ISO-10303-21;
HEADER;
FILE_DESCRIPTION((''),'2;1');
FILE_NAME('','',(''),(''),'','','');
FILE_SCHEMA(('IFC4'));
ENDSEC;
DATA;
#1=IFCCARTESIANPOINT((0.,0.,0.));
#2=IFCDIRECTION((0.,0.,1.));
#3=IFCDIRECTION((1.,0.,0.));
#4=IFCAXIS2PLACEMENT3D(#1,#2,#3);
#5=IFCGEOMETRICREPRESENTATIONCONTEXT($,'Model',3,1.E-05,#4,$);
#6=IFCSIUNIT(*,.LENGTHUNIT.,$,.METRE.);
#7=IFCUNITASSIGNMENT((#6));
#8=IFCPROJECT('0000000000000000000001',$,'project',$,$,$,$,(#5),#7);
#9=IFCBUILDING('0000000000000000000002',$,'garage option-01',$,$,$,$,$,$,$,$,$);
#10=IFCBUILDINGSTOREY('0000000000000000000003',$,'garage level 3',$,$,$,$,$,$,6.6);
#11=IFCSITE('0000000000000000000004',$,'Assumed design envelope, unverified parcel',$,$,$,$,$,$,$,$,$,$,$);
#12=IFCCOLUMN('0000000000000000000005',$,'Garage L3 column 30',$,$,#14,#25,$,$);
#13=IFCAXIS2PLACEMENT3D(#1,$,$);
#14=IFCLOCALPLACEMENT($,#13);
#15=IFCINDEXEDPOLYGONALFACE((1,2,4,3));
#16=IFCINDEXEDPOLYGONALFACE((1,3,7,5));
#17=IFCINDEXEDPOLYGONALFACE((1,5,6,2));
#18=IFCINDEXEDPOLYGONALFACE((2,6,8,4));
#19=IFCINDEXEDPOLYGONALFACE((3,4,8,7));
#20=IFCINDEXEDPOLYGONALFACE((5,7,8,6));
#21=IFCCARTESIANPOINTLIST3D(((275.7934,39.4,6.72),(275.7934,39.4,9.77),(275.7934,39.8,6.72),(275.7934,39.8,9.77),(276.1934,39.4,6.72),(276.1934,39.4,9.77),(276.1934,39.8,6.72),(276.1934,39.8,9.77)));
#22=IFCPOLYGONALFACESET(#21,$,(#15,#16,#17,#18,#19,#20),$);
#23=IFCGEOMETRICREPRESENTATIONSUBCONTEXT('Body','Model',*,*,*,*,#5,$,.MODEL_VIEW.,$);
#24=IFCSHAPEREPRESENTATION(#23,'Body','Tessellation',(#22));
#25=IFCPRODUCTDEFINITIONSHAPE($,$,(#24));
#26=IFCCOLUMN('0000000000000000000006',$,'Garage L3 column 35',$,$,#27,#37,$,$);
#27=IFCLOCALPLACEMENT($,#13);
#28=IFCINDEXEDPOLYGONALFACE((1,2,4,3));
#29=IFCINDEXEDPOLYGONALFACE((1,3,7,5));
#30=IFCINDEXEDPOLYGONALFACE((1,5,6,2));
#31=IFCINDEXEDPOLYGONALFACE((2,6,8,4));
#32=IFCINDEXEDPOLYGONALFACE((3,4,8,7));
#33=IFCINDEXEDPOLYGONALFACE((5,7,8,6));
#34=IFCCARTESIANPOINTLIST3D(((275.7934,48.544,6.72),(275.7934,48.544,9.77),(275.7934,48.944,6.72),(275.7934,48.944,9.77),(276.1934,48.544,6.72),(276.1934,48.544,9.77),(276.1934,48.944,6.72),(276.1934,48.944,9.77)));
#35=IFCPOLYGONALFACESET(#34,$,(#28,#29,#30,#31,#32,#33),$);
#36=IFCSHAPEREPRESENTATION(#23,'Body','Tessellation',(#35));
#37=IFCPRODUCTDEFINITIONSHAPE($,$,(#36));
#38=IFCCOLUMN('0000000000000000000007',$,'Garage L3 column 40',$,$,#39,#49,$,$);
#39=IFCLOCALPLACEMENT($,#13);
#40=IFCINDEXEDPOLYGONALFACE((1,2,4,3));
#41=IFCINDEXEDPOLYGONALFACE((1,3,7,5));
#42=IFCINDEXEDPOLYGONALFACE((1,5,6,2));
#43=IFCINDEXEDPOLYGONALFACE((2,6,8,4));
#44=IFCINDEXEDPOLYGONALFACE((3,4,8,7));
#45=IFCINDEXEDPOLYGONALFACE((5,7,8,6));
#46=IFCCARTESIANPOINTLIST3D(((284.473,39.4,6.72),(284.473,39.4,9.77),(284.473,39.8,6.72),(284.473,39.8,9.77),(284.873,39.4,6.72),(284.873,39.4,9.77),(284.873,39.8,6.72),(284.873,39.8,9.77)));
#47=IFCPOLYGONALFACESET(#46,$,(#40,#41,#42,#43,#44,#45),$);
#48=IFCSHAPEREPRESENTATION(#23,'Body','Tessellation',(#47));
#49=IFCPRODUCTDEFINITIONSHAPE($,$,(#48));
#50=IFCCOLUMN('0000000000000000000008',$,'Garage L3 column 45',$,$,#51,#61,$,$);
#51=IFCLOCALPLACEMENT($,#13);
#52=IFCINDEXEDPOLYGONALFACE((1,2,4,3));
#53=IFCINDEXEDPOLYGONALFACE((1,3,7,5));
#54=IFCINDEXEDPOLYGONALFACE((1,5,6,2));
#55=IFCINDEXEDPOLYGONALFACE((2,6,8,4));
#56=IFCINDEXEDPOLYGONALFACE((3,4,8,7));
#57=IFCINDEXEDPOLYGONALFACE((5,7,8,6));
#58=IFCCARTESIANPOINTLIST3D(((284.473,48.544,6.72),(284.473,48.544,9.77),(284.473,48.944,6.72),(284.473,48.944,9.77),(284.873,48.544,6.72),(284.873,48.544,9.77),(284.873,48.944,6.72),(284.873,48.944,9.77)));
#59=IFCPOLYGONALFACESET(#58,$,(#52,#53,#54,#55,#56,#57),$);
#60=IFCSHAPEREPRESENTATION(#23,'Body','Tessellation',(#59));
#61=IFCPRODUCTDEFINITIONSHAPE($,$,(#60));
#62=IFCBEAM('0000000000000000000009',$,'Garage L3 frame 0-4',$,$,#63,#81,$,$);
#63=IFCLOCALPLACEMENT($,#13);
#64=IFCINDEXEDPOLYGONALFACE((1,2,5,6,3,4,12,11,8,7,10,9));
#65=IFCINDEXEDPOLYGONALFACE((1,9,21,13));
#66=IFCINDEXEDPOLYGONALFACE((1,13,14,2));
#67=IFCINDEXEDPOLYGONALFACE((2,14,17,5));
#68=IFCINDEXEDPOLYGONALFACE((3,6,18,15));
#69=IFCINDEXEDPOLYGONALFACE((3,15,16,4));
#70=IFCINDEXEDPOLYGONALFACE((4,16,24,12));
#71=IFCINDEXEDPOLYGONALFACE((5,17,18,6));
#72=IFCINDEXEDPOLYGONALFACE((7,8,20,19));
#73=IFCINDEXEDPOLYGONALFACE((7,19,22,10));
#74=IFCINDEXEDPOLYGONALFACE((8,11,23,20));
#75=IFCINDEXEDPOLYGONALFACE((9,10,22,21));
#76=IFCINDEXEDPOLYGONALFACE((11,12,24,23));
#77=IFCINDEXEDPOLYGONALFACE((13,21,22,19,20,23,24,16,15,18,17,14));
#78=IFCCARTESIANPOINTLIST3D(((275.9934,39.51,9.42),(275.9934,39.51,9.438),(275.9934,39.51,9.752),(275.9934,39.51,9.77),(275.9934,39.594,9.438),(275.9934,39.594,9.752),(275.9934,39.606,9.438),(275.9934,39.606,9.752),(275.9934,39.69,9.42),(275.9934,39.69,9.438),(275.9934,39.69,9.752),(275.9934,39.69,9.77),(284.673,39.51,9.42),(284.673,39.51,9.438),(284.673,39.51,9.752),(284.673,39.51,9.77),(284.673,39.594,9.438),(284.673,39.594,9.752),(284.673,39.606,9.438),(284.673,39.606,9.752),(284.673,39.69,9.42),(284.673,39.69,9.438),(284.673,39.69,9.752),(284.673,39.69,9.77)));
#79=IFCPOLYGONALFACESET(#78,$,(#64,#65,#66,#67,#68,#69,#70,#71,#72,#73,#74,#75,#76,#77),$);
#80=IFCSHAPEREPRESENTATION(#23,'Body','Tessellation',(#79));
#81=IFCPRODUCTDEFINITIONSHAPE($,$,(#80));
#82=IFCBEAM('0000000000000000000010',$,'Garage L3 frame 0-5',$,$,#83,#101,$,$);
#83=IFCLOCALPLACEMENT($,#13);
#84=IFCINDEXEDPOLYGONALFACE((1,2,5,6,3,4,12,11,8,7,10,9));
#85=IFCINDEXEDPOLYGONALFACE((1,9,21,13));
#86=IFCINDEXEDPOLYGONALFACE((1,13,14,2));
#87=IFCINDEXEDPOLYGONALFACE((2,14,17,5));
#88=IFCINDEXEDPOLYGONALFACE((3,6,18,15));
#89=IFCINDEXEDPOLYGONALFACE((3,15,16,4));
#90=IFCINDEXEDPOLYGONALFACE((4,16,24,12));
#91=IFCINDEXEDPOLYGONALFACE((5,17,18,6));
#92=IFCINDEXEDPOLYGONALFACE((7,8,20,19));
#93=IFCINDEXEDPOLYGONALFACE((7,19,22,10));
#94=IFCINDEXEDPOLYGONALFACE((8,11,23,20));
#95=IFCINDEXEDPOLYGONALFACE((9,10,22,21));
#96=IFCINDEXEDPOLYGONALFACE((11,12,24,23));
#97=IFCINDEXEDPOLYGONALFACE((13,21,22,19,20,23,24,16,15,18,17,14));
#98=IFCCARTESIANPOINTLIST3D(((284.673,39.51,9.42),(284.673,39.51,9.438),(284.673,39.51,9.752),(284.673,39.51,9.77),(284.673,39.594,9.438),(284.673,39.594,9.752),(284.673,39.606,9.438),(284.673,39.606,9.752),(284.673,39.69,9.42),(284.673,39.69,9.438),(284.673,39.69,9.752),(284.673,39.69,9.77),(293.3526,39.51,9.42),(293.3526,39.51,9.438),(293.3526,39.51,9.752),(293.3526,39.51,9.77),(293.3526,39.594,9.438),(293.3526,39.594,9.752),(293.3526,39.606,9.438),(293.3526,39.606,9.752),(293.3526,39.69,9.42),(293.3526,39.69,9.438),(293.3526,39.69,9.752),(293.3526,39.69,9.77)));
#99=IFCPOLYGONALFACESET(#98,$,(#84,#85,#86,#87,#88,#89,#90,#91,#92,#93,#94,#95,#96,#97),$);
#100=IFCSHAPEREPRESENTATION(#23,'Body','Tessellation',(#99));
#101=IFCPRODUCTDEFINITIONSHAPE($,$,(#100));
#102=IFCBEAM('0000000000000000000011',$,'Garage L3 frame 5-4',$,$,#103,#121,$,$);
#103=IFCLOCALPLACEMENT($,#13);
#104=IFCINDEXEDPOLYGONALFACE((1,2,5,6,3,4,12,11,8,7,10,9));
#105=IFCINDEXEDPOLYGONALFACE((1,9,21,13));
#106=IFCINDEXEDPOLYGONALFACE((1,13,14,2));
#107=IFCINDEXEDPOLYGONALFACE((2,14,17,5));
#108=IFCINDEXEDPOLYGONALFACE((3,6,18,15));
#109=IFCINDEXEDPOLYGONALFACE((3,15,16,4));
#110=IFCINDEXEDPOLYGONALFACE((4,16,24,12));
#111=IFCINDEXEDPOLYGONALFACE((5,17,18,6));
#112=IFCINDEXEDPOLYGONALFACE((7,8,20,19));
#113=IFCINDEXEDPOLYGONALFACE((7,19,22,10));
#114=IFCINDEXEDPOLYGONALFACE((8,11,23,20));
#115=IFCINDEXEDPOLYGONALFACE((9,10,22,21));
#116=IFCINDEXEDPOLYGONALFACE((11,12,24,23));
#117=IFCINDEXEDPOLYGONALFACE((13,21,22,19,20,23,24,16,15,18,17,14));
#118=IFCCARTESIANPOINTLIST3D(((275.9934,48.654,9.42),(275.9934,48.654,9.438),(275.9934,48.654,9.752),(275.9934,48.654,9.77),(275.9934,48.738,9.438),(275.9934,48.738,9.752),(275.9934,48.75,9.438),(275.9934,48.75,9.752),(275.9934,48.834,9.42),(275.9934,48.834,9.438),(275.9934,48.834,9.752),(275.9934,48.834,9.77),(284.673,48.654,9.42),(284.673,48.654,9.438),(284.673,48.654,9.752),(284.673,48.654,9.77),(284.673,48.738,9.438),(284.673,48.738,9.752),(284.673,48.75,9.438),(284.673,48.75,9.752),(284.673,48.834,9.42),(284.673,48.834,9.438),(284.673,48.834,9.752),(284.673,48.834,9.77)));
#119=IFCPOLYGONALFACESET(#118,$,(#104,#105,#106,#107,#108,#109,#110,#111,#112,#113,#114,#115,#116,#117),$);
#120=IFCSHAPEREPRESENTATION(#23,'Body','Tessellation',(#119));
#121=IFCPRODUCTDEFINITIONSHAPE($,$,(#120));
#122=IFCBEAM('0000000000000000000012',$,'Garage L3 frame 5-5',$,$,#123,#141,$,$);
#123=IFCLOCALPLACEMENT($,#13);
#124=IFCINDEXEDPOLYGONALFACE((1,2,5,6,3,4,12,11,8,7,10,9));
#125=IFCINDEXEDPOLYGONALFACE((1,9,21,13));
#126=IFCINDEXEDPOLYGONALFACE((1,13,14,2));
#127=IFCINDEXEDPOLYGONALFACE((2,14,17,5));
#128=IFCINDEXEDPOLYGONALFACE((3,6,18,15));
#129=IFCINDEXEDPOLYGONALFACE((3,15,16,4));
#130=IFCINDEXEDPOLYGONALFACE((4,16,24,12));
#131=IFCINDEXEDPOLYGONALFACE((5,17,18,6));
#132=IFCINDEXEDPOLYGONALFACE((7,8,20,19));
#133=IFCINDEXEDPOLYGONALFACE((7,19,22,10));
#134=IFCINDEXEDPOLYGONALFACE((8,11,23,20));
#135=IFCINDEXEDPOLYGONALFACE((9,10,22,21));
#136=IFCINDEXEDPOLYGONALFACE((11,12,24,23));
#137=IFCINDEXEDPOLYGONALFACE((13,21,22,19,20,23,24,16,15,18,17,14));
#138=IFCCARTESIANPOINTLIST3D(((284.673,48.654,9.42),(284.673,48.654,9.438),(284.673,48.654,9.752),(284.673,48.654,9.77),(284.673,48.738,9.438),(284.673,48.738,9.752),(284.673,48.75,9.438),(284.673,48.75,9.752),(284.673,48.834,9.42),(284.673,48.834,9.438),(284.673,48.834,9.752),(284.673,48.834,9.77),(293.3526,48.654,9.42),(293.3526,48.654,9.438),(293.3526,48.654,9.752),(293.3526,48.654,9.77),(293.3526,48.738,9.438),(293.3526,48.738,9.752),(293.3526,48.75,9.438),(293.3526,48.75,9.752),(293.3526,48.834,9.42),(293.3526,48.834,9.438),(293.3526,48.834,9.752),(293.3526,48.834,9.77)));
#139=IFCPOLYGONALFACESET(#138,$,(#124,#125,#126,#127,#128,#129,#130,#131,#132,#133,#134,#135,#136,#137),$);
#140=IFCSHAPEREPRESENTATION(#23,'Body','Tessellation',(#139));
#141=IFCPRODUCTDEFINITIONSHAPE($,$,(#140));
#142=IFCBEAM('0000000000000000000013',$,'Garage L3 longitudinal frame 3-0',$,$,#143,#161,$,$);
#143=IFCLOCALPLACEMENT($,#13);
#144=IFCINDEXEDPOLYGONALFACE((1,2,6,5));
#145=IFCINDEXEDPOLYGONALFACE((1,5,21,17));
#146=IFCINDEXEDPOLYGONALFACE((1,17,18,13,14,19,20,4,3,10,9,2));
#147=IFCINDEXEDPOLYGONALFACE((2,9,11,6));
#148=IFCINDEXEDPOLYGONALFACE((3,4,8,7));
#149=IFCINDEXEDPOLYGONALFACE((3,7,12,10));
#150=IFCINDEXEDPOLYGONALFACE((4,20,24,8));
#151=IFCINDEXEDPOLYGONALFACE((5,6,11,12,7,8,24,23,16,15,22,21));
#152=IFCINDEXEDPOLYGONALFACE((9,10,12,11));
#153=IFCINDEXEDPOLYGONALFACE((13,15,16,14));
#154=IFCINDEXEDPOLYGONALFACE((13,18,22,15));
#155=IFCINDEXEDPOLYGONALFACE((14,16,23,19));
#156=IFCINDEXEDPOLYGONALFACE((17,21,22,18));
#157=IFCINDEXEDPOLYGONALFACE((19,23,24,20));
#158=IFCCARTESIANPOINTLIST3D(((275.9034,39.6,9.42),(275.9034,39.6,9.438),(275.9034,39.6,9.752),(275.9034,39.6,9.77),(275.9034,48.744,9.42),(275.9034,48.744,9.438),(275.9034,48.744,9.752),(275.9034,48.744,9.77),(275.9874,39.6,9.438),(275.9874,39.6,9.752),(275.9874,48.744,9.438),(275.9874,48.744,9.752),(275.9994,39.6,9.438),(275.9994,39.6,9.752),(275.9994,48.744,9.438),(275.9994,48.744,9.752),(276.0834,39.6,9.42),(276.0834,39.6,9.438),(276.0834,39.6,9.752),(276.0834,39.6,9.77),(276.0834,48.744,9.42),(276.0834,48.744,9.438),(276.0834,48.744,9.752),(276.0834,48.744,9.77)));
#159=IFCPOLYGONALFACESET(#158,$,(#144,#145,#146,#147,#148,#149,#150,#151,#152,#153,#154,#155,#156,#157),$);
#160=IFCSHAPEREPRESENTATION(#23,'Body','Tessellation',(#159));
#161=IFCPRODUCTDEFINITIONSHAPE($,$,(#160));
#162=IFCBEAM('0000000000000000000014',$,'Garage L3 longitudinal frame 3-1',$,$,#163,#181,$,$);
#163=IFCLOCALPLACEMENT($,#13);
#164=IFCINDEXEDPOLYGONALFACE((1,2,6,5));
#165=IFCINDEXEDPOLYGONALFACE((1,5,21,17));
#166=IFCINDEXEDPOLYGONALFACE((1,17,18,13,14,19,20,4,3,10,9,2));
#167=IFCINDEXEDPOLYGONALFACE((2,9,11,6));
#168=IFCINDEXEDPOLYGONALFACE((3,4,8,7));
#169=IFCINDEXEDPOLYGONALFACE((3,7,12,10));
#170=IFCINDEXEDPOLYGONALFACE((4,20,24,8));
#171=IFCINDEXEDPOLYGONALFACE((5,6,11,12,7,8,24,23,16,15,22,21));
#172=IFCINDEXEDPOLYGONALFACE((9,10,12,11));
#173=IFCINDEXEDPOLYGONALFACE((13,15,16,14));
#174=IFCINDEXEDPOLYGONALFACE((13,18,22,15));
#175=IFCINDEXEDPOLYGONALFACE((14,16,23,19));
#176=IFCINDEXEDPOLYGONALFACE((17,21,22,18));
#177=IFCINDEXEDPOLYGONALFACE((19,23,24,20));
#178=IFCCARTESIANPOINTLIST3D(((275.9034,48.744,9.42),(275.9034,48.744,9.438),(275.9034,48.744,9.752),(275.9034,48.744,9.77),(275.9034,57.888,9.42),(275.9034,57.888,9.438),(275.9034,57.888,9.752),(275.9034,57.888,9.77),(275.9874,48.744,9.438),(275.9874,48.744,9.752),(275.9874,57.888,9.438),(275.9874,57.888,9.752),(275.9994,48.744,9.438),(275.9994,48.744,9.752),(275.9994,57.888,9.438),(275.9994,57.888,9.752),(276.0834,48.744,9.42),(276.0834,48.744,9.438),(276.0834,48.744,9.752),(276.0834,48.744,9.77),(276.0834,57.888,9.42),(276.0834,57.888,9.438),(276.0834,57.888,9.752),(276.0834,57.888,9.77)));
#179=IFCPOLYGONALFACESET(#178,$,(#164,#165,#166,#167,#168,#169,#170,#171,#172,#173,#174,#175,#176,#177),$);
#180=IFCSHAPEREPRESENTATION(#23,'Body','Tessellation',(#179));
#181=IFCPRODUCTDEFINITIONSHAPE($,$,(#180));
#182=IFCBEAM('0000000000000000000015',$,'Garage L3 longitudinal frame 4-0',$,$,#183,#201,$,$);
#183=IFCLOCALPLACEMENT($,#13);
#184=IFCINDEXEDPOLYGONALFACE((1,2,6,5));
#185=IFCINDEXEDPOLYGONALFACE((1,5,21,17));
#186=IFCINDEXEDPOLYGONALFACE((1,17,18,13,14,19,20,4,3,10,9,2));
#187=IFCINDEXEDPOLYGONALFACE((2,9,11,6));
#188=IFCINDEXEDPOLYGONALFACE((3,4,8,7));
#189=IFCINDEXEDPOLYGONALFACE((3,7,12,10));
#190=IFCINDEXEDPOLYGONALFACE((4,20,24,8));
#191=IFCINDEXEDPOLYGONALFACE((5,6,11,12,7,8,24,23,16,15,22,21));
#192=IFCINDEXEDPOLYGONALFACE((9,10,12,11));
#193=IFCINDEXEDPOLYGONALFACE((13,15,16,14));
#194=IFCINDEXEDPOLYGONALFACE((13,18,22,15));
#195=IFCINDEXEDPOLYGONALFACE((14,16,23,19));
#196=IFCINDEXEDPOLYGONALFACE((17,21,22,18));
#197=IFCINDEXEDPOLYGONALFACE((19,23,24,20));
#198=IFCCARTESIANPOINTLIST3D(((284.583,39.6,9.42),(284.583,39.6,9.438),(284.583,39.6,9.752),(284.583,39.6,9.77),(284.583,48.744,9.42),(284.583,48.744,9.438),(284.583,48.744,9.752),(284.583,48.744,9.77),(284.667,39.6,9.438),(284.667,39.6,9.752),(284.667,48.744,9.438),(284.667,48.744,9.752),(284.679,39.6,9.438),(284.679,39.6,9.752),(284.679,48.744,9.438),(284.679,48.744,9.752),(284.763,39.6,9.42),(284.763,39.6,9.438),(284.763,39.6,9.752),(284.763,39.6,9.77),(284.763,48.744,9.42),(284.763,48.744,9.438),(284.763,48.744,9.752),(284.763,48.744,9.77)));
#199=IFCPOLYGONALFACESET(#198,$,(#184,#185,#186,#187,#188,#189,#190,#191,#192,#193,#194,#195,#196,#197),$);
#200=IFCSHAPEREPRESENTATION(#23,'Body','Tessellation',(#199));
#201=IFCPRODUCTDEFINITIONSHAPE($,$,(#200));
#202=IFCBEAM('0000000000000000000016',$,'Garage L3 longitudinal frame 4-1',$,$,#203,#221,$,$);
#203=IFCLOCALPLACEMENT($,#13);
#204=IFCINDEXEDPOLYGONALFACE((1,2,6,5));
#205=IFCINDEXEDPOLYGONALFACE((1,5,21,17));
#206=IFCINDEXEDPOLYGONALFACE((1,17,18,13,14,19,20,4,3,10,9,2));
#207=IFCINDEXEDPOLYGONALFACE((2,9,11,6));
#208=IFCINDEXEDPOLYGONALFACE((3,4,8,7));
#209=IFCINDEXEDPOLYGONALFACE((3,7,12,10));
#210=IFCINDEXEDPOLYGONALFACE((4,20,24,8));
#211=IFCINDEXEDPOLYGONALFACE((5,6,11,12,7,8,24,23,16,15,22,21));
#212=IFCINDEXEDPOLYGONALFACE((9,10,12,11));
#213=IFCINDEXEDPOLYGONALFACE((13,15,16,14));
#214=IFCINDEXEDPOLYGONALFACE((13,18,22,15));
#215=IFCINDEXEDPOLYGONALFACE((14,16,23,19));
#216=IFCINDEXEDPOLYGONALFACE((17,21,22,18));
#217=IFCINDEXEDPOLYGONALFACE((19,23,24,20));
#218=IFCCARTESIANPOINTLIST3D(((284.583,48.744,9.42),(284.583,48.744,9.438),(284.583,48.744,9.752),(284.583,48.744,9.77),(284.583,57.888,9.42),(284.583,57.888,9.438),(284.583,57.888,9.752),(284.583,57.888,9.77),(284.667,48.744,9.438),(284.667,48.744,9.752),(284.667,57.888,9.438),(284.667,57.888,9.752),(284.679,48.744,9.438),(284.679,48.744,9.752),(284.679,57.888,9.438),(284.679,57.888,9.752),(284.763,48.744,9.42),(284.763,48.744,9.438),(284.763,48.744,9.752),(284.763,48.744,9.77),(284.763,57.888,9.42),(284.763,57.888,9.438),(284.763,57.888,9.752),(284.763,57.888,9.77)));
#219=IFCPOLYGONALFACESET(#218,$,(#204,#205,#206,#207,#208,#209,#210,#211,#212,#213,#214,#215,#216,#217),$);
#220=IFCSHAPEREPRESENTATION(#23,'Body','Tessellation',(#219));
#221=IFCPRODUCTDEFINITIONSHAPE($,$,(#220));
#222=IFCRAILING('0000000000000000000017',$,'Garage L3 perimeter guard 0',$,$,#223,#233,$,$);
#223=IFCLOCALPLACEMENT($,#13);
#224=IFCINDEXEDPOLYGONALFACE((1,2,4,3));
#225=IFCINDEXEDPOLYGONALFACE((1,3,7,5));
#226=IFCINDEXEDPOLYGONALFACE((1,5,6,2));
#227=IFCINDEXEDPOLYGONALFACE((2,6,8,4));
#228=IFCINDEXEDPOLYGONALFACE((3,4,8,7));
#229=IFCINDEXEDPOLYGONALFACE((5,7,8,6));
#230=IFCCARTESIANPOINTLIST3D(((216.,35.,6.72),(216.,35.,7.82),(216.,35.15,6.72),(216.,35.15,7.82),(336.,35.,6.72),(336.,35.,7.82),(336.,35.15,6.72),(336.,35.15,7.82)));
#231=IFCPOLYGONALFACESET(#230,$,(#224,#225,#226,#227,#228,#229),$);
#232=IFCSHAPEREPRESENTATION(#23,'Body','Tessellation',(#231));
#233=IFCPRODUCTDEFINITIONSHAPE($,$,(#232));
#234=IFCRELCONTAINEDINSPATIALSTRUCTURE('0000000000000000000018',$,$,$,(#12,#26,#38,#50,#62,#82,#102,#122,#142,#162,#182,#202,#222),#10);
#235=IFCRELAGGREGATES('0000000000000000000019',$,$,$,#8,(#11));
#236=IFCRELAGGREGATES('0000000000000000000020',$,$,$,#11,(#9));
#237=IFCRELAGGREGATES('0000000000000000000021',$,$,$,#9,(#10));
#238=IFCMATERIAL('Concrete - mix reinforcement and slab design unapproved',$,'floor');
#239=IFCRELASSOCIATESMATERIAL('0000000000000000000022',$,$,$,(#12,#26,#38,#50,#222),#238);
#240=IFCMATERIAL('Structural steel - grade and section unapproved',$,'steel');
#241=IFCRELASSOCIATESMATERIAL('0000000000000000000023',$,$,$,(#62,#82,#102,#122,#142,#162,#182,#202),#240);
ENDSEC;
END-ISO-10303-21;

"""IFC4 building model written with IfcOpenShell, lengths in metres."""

from ifc_helpers import new_model, si_unit, frame, origin_with_axes, place, context, subcontext, project, spatial, rectangle, i_section, extrude, material, element, save


model = new_model("IFC4")

# Units and contexts
model_context = context("Model", 3, precision=1e-05, world=origin_with_axes())
body_context = subcontext(model_context, "Body", "Model", "MODEL_VIEW")
ifc_project = project(units=[si_unit("LENGTHUNIT", "METRE")], contexts=[model_context])

# Site, building, storey
site = spatial("IfcSite", under=ifc_project, Name="Assumed design envelope, unverified parcel")
building = spatial("IfcBuilding", under=site, Name="garage option-01")
storey = spatial("IfcBuildingStorey", under=building, Name="garage level 3", Elevation=6.6)

# Columns
ifc_material_1 = material(Name="Concrete - mix reinforcement and slab design unapproved", Category="floor")
for number, where, z_axis, x_axis, name in (
    (1, (275.9934, 39.6, 6.72), (0.0, 0.0, 1.0), (1.0, 0.0, 0.0), "Garage L3 column 30"),
    (2, (275.9934, 48.744, 6.72), (0.0, 0.0, 1.0), (1.0, 0.0, 0.0), "Garage L3 column 35"),
    (3, (284.673, 39.6, 6.72), (0.0, 0.0, 1.0), (1.0, 0.0, 0.0), "Garage L3 column 40"),
    (4, (284.673, 48.744, 6.72), (0.0, 0.0, 1.0), (1.0, 0.0, 0.0), "Garage L3 column 45"),
):
    element("IfcColumn", number, at=place(None, frame(where, z_axis=z_axis, x_axis=x_axis)), inside=storey, material=ifc_material_1, Name=name, context=body_context, shape_type="SweptSolid", body=[
        extrude(rectangle(XDim=0.4, YDim=0.4), origin_with_axes(), (0.0, 0.0, 1.0), 3.05),
    ])

# Beams
ifc_material_2 = material(Name="Structural steel - grade and section unapproved", Category="steel")
for number, where, z_axis, x_axis, name in (
    (5, (275.9934, 39.6, 9.595), (1.0, 0.0, 0.0), (0.0, 1.0, 0.0), "Garage L3 frame 0-4"),
    (6, (284.673, 39.6, 9.595), (1.0, 0.0, 0.0), (0.0, 1.0, 0.0), "Garage L3 frame 0-5"),
    (7, (275.9934, 48.744, 9.595), (1.0, 0.0, 0.0), (0.0, 1.0, 0.0), "Garage L3 frame 5-4"),
    (8, (284.673, 48.744, 9.595), (1.0, 0.0, 0.0), (0.0, 1.0, 0.0), "Garage L3 frame 5-5"),
):
    element("IfcBeam", number, at=place(None, frame(where, z_axis=z_axis, x_axis=x_axis)), inside=storey, material=ifc_material_2, Name=name, context=body_context, shape_type="SweptSolid", body=[
        extrude(i_section(OverallWidth=0.18, OverallDepth=0.35, WebThickness=0.012, FlangeThickness=0.018, FilletRadius=0.0), origin_with_axes(), (0.0, 0.0, 1.0), 8.6796),
    ])
for number, where, z_axis, x_axis, name in (
    (9, (275.9934, 39.6, 9.595), (0.0, 1.0, 0.0), (-1.0, 0.0, 0.0), "Garage L3 longitudinal frame 3-0"),
    (10, (275.9934, 48.744, 9.595), (0.0, 1.0, 0.0), (-1.0, 0.0, 0.0), "Garage L3 longitudinal frame 3-1"),
    (11, (284.673, 39.6, 9.595), (0.0, 1.0, 0.0), (-1.0, 0.0, 0.0), "Garage L3 longitudinal frame 4-0"),
    (12, (284.673, 48.744, 9.595), (0.0, 1.0, 0.0), (-1.0, 0.0, 0.0), "Garage L3 longitudinal frame 4-1"),
):
    element("IfcBeam", number, at=place(None, frame(where, z_axis=z_axis, x_axis=x_axis)), inside=storey, material=ifc_material_2, Name=name, context=body_context, shape_type="SweptSolid", body=[
        extrude(i_section(OverallWidth=0.18, OverallDepth=0.35, WebThickness=0.012, FlangeThickness=0.018, FilletRadius=0.0), origin_with_axes(), (0.0, 0.0, 1.0), 9.144),
    ])

# Railing
railing_placement = place(None, frame((276.0, 35.075, 6.72), z_axis=(0.0, 0.0, 1.0), x_axis=(1.0, 0.0, 0.0)))
element("IfcRailing", 13, at=railing_placement, inside=storey, material=ifc_material_1, Name="Garage L3 perimeter guard 0", context=body_context, shape_type="SweptSolid", body=[
    extrude(rectangle(XDim=120.0, YDim=0.15), origin_with_axes(), (0.0, 0.0, 1.0), 1.1),
])

save(model, "model.ifc")
